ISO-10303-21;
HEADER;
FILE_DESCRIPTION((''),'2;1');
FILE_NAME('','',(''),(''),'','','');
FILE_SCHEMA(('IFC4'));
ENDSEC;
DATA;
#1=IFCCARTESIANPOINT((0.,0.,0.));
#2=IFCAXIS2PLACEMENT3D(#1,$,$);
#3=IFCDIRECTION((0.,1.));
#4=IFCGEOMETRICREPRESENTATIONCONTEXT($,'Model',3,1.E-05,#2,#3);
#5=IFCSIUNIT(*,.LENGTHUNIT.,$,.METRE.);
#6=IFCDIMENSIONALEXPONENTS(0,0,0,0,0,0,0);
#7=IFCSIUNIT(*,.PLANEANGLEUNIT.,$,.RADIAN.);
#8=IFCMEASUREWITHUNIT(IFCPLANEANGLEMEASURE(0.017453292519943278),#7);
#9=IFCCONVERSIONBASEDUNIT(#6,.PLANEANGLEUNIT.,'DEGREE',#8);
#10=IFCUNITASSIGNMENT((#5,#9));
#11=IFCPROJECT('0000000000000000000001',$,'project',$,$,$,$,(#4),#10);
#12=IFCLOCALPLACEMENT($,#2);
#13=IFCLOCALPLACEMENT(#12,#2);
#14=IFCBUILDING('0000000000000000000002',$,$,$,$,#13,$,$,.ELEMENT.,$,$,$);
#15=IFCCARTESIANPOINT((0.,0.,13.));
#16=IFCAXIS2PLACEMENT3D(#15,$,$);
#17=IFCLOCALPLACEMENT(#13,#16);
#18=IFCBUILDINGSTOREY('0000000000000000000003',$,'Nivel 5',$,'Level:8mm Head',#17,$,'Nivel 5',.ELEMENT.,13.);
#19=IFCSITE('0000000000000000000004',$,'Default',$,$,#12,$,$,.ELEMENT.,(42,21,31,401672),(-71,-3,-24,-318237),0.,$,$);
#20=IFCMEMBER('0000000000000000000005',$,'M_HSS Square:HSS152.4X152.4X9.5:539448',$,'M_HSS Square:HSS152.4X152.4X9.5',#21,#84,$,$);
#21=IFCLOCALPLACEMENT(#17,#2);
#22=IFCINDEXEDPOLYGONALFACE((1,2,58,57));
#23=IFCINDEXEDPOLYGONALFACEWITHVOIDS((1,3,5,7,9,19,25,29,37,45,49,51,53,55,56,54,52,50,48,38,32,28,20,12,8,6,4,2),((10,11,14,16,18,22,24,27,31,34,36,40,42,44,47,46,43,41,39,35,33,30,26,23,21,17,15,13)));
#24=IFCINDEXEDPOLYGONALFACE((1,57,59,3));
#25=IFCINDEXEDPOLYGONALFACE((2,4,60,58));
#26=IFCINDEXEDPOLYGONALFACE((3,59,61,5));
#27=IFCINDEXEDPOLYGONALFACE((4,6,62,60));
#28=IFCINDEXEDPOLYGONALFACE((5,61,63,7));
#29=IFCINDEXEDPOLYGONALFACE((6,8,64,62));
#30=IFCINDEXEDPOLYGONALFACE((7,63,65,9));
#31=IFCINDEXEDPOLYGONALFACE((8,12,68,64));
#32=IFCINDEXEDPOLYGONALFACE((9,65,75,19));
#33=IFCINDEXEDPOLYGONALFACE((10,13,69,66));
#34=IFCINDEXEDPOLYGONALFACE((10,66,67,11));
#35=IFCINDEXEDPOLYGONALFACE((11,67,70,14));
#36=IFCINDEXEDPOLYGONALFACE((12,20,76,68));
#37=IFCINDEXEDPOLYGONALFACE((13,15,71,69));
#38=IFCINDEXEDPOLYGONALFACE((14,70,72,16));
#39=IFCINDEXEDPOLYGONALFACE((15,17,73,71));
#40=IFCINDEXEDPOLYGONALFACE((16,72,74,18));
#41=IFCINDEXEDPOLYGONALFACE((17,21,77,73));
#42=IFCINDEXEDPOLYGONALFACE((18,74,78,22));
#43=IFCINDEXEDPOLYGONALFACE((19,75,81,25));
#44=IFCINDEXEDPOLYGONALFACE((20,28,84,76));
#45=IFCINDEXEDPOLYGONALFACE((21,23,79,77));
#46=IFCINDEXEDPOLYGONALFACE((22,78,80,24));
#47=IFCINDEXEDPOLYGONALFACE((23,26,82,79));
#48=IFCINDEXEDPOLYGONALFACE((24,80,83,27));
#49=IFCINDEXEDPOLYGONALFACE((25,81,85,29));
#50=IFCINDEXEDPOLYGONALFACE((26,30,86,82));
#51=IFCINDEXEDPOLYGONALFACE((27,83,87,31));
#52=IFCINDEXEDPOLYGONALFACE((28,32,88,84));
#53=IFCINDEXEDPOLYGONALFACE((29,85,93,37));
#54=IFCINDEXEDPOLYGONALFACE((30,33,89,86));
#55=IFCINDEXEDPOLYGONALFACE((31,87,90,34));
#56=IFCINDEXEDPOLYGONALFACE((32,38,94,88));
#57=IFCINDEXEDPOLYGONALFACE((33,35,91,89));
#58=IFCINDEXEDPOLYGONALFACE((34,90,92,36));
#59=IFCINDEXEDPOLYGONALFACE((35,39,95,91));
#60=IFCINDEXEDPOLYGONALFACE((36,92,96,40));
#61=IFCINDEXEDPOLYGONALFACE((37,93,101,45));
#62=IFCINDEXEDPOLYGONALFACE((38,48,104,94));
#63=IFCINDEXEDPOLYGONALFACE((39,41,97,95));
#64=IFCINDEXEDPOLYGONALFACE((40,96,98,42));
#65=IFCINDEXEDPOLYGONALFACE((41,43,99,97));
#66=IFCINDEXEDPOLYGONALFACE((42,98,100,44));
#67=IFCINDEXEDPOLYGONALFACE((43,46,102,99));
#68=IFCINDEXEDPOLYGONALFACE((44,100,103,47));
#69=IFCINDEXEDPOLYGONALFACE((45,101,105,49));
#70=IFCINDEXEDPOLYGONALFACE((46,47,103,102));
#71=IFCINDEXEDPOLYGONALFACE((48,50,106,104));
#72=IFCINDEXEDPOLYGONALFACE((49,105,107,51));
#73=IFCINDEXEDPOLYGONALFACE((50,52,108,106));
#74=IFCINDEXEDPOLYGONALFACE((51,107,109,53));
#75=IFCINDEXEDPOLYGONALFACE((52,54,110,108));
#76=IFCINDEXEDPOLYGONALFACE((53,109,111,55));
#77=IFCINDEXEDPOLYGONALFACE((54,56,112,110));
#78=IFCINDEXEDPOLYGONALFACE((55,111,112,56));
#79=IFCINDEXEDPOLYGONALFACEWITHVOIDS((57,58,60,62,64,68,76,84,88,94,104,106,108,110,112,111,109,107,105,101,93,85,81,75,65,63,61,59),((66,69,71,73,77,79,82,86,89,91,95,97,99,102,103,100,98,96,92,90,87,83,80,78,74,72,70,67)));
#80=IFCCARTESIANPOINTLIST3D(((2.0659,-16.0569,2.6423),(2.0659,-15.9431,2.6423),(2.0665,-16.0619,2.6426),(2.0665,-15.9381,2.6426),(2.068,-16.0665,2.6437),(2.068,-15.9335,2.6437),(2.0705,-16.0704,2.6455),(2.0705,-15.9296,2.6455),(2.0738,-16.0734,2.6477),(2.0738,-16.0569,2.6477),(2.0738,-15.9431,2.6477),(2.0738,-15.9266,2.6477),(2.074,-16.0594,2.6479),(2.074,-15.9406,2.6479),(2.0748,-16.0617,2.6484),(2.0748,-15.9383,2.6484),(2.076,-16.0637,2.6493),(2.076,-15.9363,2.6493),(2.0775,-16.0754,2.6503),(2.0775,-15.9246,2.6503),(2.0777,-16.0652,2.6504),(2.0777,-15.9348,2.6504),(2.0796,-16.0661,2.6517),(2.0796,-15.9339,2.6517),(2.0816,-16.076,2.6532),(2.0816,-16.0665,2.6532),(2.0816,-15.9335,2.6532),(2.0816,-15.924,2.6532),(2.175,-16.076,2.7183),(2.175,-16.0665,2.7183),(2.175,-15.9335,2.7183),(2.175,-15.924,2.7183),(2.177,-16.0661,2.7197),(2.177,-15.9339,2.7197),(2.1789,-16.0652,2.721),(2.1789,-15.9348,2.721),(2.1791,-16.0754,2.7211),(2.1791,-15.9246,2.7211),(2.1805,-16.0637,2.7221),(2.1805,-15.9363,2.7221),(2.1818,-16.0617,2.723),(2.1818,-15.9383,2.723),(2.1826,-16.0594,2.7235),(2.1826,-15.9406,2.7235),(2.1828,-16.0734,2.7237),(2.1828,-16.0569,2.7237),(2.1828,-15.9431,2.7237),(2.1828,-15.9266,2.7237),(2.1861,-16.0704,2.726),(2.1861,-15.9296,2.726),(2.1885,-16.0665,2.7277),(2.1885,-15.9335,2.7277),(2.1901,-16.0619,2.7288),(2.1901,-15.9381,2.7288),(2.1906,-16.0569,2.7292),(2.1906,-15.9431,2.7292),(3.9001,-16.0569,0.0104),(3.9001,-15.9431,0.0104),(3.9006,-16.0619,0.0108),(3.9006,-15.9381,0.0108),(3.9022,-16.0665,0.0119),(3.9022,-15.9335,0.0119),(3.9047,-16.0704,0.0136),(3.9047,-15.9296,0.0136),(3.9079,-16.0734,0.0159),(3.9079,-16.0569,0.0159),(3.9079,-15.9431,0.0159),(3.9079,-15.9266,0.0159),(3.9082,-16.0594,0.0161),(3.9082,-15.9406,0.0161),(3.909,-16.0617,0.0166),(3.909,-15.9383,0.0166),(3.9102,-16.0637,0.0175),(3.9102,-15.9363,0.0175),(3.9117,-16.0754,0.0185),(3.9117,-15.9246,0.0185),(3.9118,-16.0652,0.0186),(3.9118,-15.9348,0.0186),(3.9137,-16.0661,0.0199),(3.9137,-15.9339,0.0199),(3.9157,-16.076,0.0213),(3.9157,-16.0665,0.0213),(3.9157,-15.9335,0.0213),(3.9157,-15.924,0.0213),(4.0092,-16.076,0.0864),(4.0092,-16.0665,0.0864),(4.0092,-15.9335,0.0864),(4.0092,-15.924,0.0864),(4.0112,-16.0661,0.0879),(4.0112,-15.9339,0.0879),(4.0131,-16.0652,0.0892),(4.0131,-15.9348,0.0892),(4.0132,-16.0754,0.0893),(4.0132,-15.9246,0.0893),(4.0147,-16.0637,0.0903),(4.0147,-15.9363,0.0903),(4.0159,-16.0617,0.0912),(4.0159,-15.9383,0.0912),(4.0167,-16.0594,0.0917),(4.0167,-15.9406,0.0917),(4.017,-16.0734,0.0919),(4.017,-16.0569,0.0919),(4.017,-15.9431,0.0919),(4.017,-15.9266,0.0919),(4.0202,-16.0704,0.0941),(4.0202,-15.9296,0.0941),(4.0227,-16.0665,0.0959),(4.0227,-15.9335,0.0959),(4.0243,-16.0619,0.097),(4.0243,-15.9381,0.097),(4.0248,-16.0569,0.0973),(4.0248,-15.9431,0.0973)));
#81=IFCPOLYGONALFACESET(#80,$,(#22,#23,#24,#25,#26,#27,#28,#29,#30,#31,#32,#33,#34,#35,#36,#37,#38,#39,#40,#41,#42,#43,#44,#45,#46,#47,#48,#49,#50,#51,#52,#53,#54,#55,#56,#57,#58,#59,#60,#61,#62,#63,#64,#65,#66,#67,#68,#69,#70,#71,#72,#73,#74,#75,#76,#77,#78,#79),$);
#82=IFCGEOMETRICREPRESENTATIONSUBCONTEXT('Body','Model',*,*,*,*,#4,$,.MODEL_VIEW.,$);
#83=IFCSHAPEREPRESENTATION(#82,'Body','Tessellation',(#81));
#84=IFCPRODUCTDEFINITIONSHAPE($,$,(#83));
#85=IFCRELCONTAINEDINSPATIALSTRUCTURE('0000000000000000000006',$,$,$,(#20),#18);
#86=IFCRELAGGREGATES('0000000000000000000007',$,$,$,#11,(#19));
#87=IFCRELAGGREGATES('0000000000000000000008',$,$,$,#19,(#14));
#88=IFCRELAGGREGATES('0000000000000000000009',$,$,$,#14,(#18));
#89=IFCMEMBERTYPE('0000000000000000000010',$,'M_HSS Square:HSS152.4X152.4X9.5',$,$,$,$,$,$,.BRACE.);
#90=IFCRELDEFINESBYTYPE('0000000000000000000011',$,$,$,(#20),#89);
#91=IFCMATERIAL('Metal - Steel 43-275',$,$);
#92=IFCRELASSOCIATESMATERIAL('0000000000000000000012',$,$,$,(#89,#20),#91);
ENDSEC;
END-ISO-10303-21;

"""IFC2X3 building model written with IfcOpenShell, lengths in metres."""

from ifc_helpers import new_model, entity, si_unit, converted_unit, direction, frame, frame_2d, origin, place, context, subcontext, project, spatial, polyline, circle_curve, parameter, trimmed, segment, composite_curve, outline, extrude, source, transform, mapped, material, type_object, type_shapes, element, save


model = new_model("IFC2X3")

# Units and contexts
model_context = context("Model", 3, precision=1e-05, world=origin(), true_north=direction((0.0, 1.0)))
body_context = subcontext(model_context, "Body", "Model", "MODEL_VIEW")
ifc_project = project(units=[si_unit("LENGTHUNIT", "METRE"), converted_unit("PLANEANGLEUNIT", "DEGREE", entity("IfcPlaneAngleMeasure", 0.017453292519943278), si_unit("PLANEANGLEUNIT", "RADIAN"), dimensions=[0, 0, 0, 0, 0, 0, 0])], contexts=[model_context])

# Site, building, storey
site_placement = place(None, origin())
site = spatial("IfcSite", under=ifc_project, at=site_placement, Name="Default", CompositionType="ELEMENT", RefLatitude=(42, 21, 31, 401672), RefLongitude=(-71, -3, -24, -318237), RefElevation=0.0)
building_placement = place(site_placement, origin())
building = spatial("IfcBuilding", under=site, at=building_placement, CompositionType="ELEMENT")
storey_placement = place(building_placement, frame((0.0, 0.0, 13.0)))
storey = spatial("IfcBuildingStorey", under=building, at=storey_placement, Name="Nivel 5", ObjectType="Level:8mm Head", LongName="Nivel 5", CompositionType="ELEMENT", Elevation=13.0)

# Shared definitions
ifc_material_1 = material(Name="Metal - Steel 43-275")

# Member
member_type_1 = type_object("IfcMemberType", Name="M_HSS Square:HSS152.4X152.4X9.5", PredefinedType="BRACE", material=ifc_material_1)
shared_shape_1 = source(origin(), body_context, "Body", "SweptSolid", [
    extrude(outline(composite_curve([segment(polyline([(-0.0569, -0.076), (0.0569, -0.076)]), True, "CONTINUOUS"), segment(trimmed(circle_curve(frame_2d((0.0569, -0.0569), x_axis=(0.0, 1.0)), 0.0191), [parameter(180.0)], [parameter(270.0)], True, "PARAMETER"), True, "CONTINUOUS"), segment(polyline([(0.076, -0.0569), (0.076, 0.0569)]), True, "CONTINUOUS"), segment(trimmed(circle_curve(frame_2d((0.0569, 0.0569), x_axis=(0.0, 1.0)), 0.0191), [parameter(270.0)], [parameter(0.0)], True, "PARAMETER"), True, "CONTINUOUS"), segment(polyline([(0.0569, 0.076), (-0.0569, 0.076)]), True, "CONTINUOUS"), segment(trimmed(circle_curve(frame_2d((-0.0569, 0.0569), x_axis=(0.0, 1.0)), 0.0191), [parameter(0.0)], [parameter(90.0)], True, "PARAMETER"), True, "CONTINUOUS"), segment(polyline([(-0.076, 0.0569), (-0.076, -0.0569)]), True, "CONTINUOUS"), segment(trimmed(circle_curve(frame_2d((-0.0569, -0.0569), x_axis=(0.0, 1.0)), 0.0191), [parameter(90.0)], [parameter(180.0)], True, "PARAMETER"), True, "CONTINUOUS")], self_intersect=False), holes=[composite_curve([segment(trimmed(circle_curve(frame_2d((-0.0569, 0.0569), x_axis=(0.0, 1.0)), 0.0095), [parameter(360.0)], [parameter(90.0)], True, "PARAMETER"), False, "CONTINUOUS"), segment(polyline([(-0.0569, 0.0665), (0.0569, 0.0665)]), True, "CONTINUOUS"), segment(trimmed(circle_curve(frame_2d((0.0569, 0.0569), x_axis=(0.0, 1.0)), 0.0095), [parameter(270.0)], [parameter(360.0)], True, "PARAMETER"), False, "CONTINUOUS"), segment(polyline([(0.0665, 0.0569), (0.0665, -0.0569)]), True, "CONTINUOUS"), segment(trimmed(circle_curve(frame_2d((0.0569, -0.0569), x_axis=(0.0, 1.0)), 0.0095), [parameter(180.0)], [parameter(270.0)], True, "PARAMETER"), False, "CONTINUOUS"), segment(polyline([(0.0569, -0.0665), (-0.0569, -0.0665)]), True, "CONTINUOUS"), segment(trimmed(circle_curve(frame_2d((-0.0569, -0.0569), x_axis=(0.0, 1.0)), 0.0095), [parameter(90.0)], [parameter(180.0)], True, "PARAMETER"), False, "CONTINUOUS"), segment(polyline([(-0.0665, -0.0569), (-0.0665, 0.0569)]), True, "CONTINUOUS")], self_intersect=False)]), frame((-1.6833, 0.0, 0.0), z_axis=(1.0, 0.0, 0.0), x_axis=(0.0, 0.0, -1.0)), (0.0, 0.0, 1.0), 3.2079),
])
type_shapes(member_type_1, [shared_shape_1])
member_1_placement = place(storey_placement, frame((3.0, -16.0, 1.4349), z_axis=(0.82042, 0.0, 0.571761), x_axis=(-0.571761, 0.0, 0.82042)))
element("IfcMember", 1, at=member_1_placement, inside=storey, type_object=member_type_1, material=ifc_material_1, Name="M_HSS Square:HSS152.4X152.4X9.5:539448", ObjectType="M_HSS Square:HSS152.4X152.4X9.5", context=body_context, shape_type="MappedRepresentation", body=[
    mapped(shared_shape_1, transform((0.0, 0.0, 0.0), scale=1.0)),
])

save(model, "model.ifc")
